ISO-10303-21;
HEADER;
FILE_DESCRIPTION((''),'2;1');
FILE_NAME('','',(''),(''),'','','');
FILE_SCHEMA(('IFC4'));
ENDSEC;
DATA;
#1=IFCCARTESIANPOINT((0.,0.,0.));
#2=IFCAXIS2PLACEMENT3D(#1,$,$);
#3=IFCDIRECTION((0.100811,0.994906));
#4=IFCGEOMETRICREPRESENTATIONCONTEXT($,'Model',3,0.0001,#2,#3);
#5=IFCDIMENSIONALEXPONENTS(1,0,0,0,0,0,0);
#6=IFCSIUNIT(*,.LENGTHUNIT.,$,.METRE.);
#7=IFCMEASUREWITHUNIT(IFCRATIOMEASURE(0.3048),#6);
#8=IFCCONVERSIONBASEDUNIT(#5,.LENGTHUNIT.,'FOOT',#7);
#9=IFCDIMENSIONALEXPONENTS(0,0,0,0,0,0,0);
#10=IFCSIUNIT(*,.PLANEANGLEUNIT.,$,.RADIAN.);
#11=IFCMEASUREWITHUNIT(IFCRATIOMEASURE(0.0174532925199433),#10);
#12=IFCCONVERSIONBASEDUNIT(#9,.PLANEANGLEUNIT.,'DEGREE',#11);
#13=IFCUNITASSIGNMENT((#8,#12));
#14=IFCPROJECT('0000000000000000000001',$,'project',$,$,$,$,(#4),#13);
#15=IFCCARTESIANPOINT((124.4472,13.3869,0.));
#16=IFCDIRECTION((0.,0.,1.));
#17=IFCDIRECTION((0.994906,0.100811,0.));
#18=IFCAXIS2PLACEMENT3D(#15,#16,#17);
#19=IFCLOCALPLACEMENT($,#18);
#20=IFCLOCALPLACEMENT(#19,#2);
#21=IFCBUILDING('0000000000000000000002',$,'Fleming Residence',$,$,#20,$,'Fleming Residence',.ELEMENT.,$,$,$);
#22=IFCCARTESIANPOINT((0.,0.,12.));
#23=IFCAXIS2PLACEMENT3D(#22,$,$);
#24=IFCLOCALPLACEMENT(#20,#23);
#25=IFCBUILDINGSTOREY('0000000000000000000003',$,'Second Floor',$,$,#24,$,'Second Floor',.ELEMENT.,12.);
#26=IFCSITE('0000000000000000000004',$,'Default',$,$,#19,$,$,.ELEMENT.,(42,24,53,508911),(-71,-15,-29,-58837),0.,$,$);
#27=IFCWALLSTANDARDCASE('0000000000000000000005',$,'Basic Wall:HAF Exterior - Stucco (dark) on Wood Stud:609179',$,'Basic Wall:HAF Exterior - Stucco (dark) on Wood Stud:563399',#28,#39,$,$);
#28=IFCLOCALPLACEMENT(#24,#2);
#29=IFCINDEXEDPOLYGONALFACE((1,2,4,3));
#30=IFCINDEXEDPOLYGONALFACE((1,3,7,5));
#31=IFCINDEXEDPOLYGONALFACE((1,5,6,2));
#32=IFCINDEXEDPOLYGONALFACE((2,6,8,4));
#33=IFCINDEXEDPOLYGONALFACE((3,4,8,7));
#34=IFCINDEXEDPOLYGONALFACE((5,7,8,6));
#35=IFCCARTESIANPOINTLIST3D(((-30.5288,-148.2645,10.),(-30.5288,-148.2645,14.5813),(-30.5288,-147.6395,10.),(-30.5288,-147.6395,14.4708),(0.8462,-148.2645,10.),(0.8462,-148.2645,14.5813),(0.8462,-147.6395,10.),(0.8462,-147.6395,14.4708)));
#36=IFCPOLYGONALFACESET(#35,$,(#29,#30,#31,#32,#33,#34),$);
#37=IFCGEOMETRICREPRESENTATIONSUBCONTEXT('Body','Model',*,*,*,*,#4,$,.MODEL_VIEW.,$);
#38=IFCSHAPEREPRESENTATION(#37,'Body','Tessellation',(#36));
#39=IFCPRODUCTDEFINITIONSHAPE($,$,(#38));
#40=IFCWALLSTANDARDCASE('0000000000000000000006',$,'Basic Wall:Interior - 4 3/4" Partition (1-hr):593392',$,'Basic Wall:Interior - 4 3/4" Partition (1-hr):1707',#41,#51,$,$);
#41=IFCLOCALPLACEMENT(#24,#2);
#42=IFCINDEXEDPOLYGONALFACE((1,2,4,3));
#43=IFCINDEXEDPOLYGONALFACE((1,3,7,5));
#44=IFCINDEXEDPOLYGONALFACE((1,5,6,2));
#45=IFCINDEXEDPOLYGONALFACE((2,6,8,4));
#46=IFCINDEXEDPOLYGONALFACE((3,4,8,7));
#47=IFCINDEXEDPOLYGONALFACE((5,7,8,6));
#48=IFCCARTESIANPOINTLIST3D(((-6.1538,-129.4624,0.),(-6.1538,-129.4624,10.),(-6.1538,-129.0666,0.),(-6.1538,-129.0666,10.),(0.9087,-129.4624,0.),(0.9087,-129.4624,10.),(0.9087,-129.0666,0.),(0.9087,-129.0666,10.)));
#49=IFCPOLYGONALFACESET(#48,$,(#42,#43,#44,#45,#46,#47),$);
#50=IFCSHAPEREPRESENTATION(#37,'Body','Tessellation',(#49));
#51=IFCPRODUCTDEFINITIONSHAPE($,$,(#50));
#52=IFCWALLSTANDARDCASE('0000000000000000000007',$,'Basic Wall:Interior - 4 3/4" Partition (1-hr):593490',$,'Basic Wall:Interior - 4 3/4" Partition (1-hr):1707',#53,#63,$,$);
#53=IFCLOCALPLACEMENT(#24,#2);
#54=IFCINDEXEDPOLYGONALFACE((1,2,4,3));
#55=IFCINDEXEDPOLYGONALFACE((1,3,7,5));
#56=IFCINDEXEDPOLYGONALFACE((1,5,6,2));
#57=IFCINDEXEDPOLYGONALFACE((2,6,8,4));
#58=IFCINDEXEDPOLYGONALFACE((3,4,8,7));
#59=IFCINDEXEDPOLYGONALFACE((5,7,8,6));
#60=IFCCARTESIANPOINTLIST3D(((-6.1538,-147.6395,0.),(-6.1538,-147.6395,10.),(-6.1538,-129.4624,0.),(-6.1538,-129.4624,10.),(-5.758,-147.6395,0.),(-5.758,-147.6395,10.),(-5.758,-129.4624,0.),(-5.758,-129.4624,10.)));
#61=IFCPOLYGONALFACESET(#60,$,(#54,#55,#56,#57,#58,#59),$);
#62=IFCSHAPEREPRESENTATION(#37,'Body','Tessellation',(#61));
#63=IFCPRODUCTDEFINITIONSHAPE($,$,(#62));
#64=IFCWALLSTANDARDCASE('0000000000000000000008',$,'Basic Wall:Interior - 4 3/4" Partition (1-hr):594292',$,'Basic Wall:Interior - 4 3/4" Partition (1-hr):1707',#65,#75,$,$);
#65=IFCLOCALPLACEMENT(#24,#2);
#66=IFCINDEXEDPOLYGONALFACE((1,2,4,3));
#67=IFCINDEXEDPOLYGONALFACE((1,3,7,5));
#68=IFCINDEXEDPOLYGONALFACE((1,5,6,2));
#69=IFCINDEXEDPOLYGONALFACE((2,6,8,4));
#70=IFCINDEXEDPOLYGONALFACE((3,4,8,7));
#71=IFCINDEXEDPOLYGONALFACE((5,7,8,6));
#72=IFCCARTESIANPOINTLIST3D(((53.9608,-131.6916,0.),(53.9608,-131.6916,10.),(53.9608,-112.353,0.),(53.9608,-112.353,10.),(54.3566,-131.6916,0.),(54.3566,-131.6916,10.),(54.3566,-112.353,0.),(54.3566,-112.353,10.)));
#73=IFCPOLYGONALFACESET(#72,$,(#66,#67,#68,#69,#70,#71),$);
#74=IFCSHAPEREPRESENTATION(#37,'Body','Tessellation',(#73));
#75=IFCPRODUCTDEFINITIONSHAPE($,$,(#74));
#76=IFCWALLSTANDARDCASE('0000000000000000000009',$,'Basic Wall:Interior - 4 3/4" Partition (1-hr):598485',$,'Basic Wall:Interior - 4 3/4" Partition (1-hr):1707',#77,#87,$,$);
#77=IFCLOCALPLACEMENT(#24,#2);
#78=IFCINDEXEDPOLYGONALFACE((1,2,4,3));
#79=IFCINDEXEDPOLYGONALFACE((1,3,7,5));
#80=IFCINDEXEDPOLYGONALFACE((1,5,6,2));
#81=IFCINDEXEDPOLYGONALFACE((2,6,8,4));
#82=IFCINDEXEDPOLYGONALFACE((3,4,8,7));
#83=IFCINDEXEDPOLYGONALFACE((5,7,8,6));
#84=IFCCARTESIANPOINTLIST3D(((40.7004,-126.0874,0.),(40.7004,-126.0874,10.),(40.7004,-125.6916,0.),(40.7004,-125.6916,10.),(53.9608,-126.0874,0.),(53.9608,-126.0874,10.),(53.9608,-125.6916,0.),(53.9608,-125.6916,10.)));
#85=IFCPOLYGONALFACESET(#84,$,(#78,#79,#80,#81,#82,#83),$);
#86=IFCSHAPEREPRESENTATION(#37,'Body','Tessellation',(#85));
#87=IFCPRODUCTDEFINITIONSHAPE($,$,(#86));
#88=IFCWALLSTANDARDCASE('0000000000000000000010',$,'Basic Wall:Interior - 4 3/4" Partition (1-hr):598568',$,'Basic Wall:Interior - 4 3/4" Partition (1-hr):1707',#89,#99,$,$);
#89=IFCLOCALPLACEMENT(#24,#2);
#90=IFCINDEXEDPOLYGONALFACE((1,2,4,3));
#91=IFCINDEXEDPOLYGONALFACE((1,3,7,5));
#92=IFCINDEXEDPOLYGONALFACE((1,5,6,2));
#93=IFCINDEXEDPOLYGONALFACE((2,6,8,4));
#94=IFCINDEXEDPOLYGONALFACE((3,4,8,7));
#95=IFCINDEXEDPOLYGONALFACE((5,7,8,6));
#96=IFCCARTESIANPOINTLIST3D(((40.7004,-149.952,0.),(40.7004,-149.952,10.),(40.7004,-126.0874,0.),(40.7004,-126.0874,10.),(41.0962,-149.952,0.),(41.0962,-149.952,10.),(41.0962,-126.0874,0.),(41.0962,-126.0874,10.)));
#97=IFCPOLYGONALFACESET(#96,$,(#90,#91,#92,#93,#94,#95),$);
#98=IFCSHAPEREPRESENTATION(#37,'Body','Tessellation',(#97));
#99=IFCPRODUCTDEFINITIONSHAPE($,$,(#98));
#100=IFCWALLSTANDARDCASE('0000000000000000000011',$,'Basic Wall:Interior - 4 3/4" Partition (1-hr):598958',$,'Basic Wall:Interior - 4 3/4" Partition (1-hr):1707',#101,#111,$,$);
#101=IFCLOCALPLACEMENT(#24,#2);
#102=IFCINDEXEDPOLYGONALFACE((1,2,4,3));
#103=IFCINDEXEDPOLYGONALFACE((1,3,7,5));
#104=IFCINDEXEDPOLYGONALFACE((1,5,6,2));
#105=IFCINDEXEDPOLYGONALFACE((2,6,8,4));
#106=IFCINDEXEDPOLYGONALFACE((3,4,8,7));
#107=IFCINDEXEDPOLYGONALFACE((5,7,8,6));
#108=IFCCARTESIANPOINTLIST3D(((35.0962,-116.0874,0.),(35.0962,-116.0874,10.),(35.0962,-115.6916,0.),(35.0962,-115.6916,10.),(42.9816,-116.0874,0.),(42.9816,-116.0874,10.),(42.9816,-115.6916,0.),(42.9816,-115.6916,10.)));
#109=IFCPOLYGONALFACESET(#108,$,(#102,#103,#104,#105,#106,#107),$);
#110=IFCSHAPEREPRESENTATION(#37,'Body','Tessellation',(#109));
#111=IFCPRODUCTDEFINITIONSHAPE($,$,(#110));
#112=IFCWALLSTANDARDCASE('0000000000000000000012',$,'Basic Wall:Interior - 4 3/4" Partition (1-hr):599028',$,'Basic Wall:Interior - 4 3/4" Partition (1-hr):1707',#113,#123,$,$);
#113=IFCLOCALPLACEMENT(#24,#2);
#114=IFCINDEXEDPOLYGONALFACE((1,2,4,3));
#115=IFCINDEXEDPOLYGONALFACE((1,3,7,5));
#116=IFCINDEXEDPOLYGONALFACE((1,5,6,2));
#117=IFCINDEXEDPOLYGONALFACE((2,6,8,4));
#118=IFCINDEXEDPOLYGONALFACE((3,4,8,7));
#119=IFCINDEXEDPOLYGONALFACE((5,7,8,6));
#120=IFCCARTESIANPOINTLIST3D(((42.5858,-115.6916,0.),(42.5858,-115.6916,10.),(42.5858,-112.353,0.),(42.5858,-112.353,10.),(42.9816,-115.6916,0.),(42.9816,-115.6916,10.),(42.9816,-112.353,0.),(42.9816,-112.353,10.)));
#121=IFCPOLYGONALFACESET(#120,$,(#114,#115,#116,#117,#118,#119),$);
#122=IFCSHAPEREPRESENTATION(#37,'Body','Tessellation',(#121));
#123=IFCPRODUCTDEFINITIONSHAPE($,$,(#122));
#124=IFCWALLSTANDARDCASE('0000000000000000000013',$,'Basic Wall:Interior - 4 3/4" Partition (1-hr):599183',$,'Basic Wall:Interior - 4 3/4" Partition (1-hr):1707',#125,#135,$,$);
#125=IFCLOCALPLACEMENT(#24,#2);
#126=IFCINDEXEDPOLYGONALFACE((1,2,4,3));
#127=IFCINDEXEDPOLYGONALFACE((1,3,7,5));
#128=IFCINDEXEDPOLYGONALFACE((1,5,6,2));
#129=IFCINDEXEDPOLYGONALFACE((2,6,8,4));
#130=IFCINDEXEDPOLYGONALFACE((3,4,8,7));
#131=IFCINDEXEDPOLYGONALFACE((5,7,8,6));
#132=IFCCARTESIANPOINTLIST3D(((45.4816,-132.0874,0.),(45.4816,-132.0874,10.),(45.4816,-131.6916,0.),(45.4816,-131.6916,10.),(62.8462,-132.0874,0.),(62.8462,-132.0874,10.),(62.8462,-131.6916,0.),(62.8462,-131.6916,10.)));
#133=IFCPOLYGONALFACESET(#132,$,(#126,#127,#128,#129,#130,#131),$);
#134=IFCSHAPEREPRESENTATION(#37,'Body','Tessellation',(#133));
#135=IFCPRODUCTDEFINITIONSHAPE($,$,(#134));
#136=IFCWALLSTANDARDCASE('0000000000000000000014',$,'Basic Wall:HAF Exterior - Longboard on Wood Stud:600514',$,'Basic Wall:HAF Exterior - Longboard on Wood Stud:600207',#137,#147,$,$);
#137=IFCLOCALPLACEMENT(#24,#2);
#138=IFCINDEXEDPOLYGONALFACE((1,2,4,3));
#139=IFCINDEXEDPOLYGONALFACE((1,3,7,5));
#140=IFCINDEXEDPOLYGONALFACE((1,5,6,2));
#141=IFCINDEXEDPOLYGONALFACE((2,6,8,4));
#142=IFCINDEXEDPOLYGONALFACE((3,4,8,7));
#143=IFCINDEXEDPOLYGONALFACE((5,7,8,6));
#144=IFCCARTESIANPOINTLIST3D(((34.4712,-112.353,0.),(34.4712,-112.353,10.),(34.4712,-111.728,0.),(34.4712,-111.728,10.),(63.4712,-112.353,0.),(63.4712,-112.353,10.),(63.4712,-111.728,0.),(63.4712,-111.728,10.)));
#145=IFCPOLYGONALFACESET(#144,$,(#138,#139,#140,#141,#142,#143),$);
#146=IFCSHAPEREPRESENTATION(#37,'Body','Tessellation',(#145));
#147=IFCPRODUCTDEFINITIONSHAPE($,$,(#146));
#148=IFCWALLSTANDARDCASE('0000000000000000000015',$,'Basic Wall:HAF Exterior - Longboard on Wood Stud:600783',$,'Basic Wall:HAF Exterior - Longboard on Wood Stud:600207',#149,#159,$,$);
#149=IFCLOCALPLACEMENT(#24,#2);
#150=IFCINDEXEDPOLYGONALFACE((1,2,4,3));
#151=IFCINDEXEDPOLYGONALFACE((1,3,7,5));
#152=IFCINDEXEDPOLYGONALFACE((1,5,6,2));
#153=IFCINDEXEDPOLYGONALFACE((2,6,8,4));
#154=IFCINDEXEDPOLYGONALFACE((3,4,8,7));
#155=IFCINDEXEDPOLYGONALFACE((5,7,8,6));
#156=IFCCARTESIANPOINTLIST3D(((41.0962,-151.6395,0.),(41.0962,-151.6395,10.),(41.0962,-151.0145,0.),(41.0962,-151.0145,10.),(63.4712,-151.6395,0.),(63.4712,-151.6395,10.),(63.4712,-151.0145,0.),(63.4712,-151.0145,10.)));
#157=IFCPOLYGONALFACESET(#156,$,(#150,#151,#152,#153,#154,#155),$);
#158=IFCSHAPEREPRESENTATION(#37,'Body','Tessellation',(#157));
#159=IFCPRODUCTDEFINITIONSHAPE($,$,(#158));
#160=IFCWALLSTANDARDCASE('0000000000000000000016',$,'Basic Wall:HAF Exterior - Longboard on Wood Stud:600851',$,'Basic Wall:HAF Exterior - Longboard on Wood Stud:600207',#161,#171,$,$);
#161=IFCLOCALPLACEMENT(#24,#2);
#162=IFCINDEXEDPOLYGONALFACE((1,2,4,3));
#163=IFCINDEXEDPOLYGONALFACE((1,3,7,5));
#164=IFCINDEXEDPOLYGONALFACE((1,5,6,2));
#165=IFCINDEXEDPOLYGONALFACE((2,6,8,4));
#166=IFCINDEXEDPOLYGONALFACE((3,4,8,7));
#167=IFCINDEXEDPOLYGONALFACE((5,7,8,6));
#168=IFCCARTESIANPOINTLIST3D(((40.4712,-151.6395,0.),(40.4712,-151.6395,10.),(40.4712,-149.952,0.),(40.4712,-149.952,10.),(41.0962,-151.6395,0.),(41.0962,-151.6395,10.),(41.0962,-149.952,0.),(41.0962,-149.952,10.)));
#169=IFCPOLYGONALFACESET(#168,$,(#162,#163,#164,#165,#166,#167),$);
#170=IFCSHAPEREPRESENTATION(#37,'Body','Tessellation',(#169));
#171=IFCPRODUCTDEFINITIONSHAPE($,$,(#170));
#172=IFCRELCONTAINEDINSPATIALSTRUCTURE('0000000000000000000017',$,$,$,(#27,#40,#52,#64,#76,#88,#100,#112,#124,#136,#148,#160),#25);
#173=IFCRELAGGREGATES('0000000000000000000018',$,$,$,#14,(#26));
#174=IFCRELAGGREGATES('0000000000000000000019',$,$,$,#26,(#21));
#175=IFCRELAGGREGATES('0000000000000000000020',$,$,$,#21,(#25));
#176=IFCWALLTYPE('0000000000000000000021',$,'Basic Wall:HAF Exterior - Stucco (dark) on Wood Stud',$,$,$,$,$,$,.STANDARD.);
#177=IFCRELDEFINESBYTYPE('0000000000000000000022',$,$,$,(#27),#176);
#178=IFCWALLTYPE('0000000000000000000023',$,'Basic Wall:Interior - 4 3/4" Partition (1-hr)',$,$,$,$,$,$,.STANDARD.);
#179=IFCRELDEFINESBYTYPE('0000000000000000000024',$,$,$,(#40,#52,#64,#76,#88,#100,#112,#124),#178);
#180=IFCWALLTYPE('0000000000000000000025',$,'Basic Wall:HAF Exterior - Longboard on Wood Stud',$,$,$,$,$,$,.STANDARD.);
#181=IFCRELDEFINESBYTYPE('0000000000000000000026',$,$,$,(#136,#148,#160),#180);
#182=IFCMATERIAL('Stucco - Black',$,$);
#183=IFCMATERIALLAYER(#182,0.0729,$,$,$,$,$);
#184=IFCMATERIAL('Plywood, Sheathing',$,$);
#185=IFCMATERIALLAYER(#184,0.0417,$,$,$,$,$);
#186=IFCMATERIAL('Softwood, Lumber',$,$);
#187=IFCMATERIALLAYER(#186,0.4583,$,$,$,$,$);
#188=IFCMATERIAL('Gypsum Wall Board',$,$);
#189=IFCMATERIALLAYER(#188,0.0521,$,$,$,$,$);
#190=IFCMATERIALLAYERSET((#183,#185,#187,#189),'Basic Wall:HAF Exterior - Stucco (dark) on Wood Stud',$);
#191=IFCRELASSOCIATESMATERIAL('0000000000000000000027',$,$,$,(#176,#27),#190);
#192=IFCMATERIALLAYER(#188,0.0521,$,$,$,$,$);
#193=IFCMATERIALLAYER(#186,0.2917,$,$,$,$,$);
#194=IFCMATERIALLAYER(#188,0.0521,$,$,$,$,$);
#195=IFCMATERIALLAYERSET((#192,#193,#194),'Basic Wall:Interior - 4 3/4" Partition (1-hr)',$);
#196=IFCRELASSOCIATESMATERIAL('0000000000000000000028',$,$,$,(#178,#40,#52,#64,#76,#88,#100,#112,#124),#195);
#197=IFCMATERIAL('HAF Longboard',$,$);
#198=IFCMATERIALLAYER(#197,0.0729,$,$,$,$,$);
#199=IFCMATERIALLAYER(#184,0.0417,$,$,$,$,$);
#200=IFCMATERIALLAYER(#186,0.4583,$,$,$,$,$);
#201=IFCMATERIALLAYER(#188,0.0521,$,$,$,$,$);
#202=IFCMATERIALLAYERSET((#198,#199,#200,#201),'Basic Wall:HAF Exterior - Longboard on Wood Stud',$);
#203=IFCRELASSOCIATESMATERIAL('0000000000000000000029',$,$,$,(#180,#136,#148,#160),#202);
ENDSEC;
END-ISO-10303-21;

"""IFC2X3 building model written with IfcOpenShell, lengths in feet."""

from ifc_helpers import new_model, entity, si_unit, converted_unit, direction, frame, frame_2d, origin, place, context, subcontext, project, spatial, polyline, rectangle, extrude, clip, bounded_halfspace, material, layer, layer_set, layer_usage, type_object, element, save


model = new_model("IFC2X3")

# Units and contexts
model_context = context("Model", 3, precision=0.0001, world=origin(), true_north=direction((0.100811, 0.994906)))
body_context = subcontext(model_context, "Body", "Model", "MODEL_VIEW")
ifc_project = project(units=[converted_unit("LENGTHUNIT", "FOOT", entity("IfcRatioMeasure", 0.3048), si_unit("LENGTHUNIT", "METRE"), dimensions=[1, 0, 0, 0, 0, 0, 0]), converted_unit("PLANEANGLEUNIT", "DEGREE", entity("IfcRatioMeasure", 0.0174532925199433), si_unit("PLANEANGLEUNIT", "RADIAN"), dimensions=[0, 0, 0, 0, 0, 0, 0])], contexts=[model_context])

# Site, building, storey
site_placement = place(None, frame((124.4472, 13.3869, 0.0), z_axis=(0.0, 0.0, 1.0), x_axis=(0.994906, 0.100811, 0.0)))
site = spatial("IfcSite", under=ifc_project, at=site_placement, Name="Default", CompositionType="ELEMENT", RefLatitude=(42, 24, 53, 508911), RefLongitude=(-71, -15, -29, -58837), RefElevation=0.0)
building_placement = place(site_placement, origin())
building = spatial("IfcBuilding", under=site, at=building_placement, Name="Fleming Residence", LongName="Fleming Residence", CompositionType="ELEMENT")
storey_placement = place(building_placement, frame((0.0, 0.0, 12.0)))
storey = spatial("IfcBuildingStorey", under=building, at=storey_placement, Name="Second Floor", LongName="Second Floor", CompositionType="ELEMENT", Elevation=12.0)

# Walls
ifc_material_1 = material(Name="Plywood, Sheathing")
ifc_material_2 = material(Name="Softwood, Lumber")
ifc_material_3 = material(Name="Gypsum Wall Board")
ifc_material_4 = material(Name="Stucco - Black")
ifc_layer_1 = layer(ifc_material_4, 0.0729)
ifc_layer_2 = layer(ifc_material_1, 0.0417)
ifc_layer_3 = layer(ifc_material_2, 0.4583)
ifc_layer_4 = layer(ifc_material_3, 0.0521)
ifc_layer_set_1 = layer_set([ifc_layer_1, ifc_layer_2, ifc_layer_3, ifc_layer_4], Name="Basic Wall:HAF Exterior - Stucco (dark) on Wood Stud")
wall_type_1 = type_object("IfcWallType", Name="Basic Wall:HAF Exterior - Stucco (dark) on Wood Stud", PredefinedType="STANDARD", material=ifc_layer_set_1)
ifc_layer_usage_1 = layer_usage(ifc_layer_set_1, "AXIS2", "NEGATIVE", 0.3125)
wall_1_placement = place(storey_placement, frame((0.8462, -147.952, 10.0), z_axis=(0.0, 0.0, 1.0), x_axis=(-1.0, 0.0, 0.0)))
element("IfcWallStandardCase", 1, at=wall_1_placement, inside=storey, type_object=wall_type_1, material=ifc_layer_usage_1, Name="Basic Wall:HAF Exterior - Stucco (dark) on Wood Stud:609179", ObjectType="Basic Wall:HAF Exterior - Stucco (dark) on Wood Stud:563399", context=body_context, shape_type="Clipping", body=[
    clip(extrude(rectangle(XDim=31.375, YDim=0.625, at=frame_2d((15.6875, 0.0), x_axis=(-1.0, 0.0))), origin(), (0.0, 0.0, 1.0), 4.5813), bounded_halfspace(frame((0.0, -0.3125, 4.4708), z_axis=(0.0, 0.174064, -0.984734), x_axis=(1.0, 0.0, 0.0)), True, frame((0.0, -0.3125, 4.4708)), polyline([(0.0, 0.0), (30.75, 0.0), (31.375, 0.0), (31.375, 0.625), (0.0, 0.625), (0.0, 0.0)]))),
])
ifc_layer_5 = layer(ifc_material_3, 0.0521)
ifc_layer_6 = layer(ifc_material_2, 0.2917)
ifc_layer_7 = layer(ifc_material_3, 0.0521)
ifc_layer_set_2 = layer_set([ifc_layer_5, ifc_layer_6, ifc_layer_7], Name="Basic Wall:Interior - 4 3/4\" Partition (1-hr)")
ifc_layer_usage_2 = layer_usage(ifc_layer_set_2, "AXIS2", "NEGATIVE", 0.1979)
wall_type_2 = type_object("IfcWallType", Name="Basic Wall:Interior - 4 3/4\" Partition (1-hr)", PredefinedType="STANDARD", material=ifc_layer_set_2)
wall_2_placement = place(storey_placement, frame((0.9087, -129.2645, 0.0), z_axis=(0.0, 0.0, 1.0), x_axis=(-1.0, 0.0, 0.0)))
element("IfcWallStandardCase", 2, at=wall_2_placement, inside=storey, type_object=wall_type_2, material=ifc_layer_usage_2, Name="Basic Wall:Interior - 4 3/4\" Partition (1-hr):593392", ObjectType="Basic Wall:Interior - 4 3/4\" Partition (1-hr):1707", context=body_context, shape_type="SweptSolid", body=[
    extrude(rectangle(XDim=7.0625, YDim=0.3958, at=frame_2d((3.5313, 0.0), x_axis=(-1.0, 0.0))), origin(), (0.0, 0.0, 1.0), 10.0),
])
ifc_layer_usage_3 = layer_usage(ifc_layer_set_2, "AXIS2", "NEGATIVE", 0.1979)
wall_3_placement = place(storey_placement, frame((-5.9559, -129.4624, 0.0), z_axis=(0.0, 0.0, 1.0), x_axis=(0.0, -1.0, 0.0)))
element("IfcWallStandardCase", 3, at=wall_3_placement, inside=storey, type_object=wall_type_2, material=ifc_layer_usage_3, Name="Basic Wall:Interior - 4 3/4\" Partition (1-hr):593490", ObjectType="Basic Wall:Interior - 4 3/4\" Partition (1-hr):1707", context=body_context, shape_type="SweptSolid", body=[
    extrude(rectangle(XDim=18.1771, YDim=0.3958, at=frame_2d((9.0885, 0.0), x_axis=(-1.0, 0.0))), origin(), (0.0, 0.0, 1.0), 10.0),
])
ifc_layer_usage_4 = layer_usage(ifc_layer_set_2, "AXIS2", "NEGATIVE", 0.1979)
wall_4_placement = place(storey_placement, frame((54.1587, -112.353, 0.0), z_axis=(0.0, 0.0, 1.0), x_axis=(0.0, -1.0, 0.0)))
element("IfcWallStandardCase", 4, at=wall_4_placement, inside=storey, type_object=wall_type_2, material=ifc_layer_usage_4, Name="Basic Wall:Interior - 4 3/4\" Partition (1-hr):594292", ObjectType="Basic Wall:Interior - 4 3/4\" Partition (1-hr):1707", context=body_context, shape_type="SweptSolid", body=[
    extrude(rectangle(XDim=19.3385, YDim=0.3958, at=frame_2d((9.6693, 0.0), x_axis=(-1.0, 0.0))), origin(), (0.0, 0.0, 1.0), 10.0),
])
ifc_layer_usage_5 = layer_usage(ifc_layer_set_2, "AXIS2", "NEGATIVE", 0.1979)
wall_5_placement = place(storey_placement, frame((53.9608, -125.8895, 0.0), z_axis=(0.0, 0.0, 1.0), x_axis=(-1.0, 0.0, 0.0)))
element("IfcWallStandardCase", 5, at=wall_5_placement, inside=storey, type_object=wall_type_2, material=ifc_layer_usage_5, Name="Basic Wall:Interior - 4 3/4\" Partition (1-hr):598485", ObjectType="Basic Wall:Interior - 4 3/4\" Partition (1-hr):1707", context=body_context, shape_type="SweptSolid", body=[
    extrude(rectangle(XDim=13.2604, YDim=0.3958, at=frame_2d((6.6302, 0.0), x_axis=(-1.0, 0.0))), origin(), (0.0, 0.0, 1.0), 10.0),
])
ifc_layer_usage_6 = layer_usage(ifc_layer_set_2, "AXIS2", "NEGATIVE", 0.1979)
wall_6_placement = place(storey_placement, frame((40.8983, -126.0874, 0.0), z_axis=(0.0, 0.0, 1.0), x_axis=(0.0, -1.0, 0.0)))
element("IfcWallStandardCase", 6, at=wall_6_placement, inside=storey, type_object=wall_type_2, material=ifc_layer_usage_6, Name="Basic Wall:Interior - 4 3/4\" Partition (1-hr):598568", ObjectType="Basic Wall:Interior - 4 3/4\" Partition (1-hr):1707", context=body_context, shape_type="SweptSolid", body=[
    extrude(rectangle(XDim=23.8646, YDim=0.3958, at=frame_2d((11.9323, 0.0), x_axis=(-1.0, 0.0))), origin(), (0.0, 0.0, 1.0), 10.0),
])
ifc_layer_usage_7 = layer_usage(ifc_layer_set_2, "AXIS2", "NEGATIVE", 0.1979)
wall_7_placement = place(storey_placement, frame((35.0962, -115.8895, 0.0)))
element("IfcWallStandardCase", 7, at=wall_7_placement, inside=storey, type_object=wall_type_2, material=ifc_layer_usage_7, Name="Basic Wall:Interior - 4 3/4\" Partition (1-hr):598958", ObjectType="Basic Wall:Interior - 4 3/4\" Partition (1-hr):1707", context=body_context, shape_type="SweptSolid", body=[
    extrude(rectangle(XDim=7.8854, YDim=0.3958, at=frame_2d((3.9427, 0.0), x_axis=(-1.0, 0.0))), origin(), (0.0, 0.0, 1.0), 10.0),
])
ifc_layer_usage_8 = layer_usage(ifc_layer_set_2, "AXIS2", "NEGATIVE", 0.1979)
wall_8_placement = place(storey_placement, frame((42.7837, -115.6916, 0.0), z_axis=(0.0, 0.0, 1.0), x_axis=(0.0, 1.0, 0.0)))
element("IfcWallStandardCase", 8, at=wall_8_placement, inside=storey, type_object=wall_type_2, material=ifc_layer_usage_8, Name="Basic Wall:Interior - 4 3/4\" Partition (1-hr):599028", ObjectType="Basic Wall:Interior - 4 3/4\" Partition (1-hr):1707", context=body_context, shape_type="SweptSolid", body=[
    extrude(rectangle(XDim=3.3385, YDim=0.3958, at=frame_2d((1.6693, 0.0), x_axis=(-1.0, 0.0))), origin(), (0.0, 0.0, 1.0), 10.0),
])
ifc_layer_usage_9 = layer_usage(ifc_layer_set_2, "AXIS2", "NEGATIVE", 0.1979)
wall_9_placement = place(storey_placement, frame((45.4816, -131.8895, 0.0)))
element("IfcWallStandardCase", 9, at=wall_9_placement, inside=storey, type_object=wall_type_2, material=ifc_layer_usage_9, Name="Basic Wall:Interior - 4 3/4\" Partition (1-hr):599183", ObjectType="Basic Wall:Interior - 4 3/4\" Partition (1-hr):1707", context=body_context, shape_type="SweptSolid", body=[
    extrude(rectangle(XDim=17.3646, YDim=0.3958, at=frame_2d((8.6823, 0.0), x_axis=(-1.0, 0.0))), origin(), (0.0, 0.0, 1.0), 10.0),
])
ifc_material_5 = material(Name="HAF Longboard")
ifc_layer_8 = layer(ifc_material_5, 0.0729)
ifc_layer_9 = layer(ifc_material_1, 0.0417)
ifc_layer_10 = layer(ifc_material_2, 0.4583)
ifc_layer_11 = layer(ifc_material_3, 0.0521)
ifc_layer_set_3 = layer_set([ifc_layer_8, ifc_layer_9, ifc_layer_10, ifc_layer_11], Name="Basic Wall:HAF Exterior - Longboard on Wood Stud")
ifc_layer_usage_10 = layer_usage(ifc_layer_set_3, "AXIS2", "NEGATIVE", 0.3125)
wall_type_3 = type_object("IfcWallType", Name="Basic Wall:HAF Exterior - Longboard on Wood Stud", PredefinedType="STANDARD", material=ifc_layer_set_3)
wall_10_placement = place(storey_placement, frame((34.4712, -112.0405, 0.0)))
element("IfcWallStandardCase", 10, at=wall_10_placement, inside=storey, type_object=wall_type_3, material=ifc_layer_usage_10, Name="Basic Wall:HAF Exterior - Longboard on Wood Stud:600514", ObjectType="Basic Wall:HAF Exterior - Longboard on Wood Stud:600207", context=body_context, shape_type="Clipping", body=[
    clip(extrude(rectangle(XDim=29.0, YDim=0.625, at=frame_2d((14.5, 0.0), x_axis=(-1.0, 0.0))), origin(), (0.0, 0.0, 1.0), 10.0), bounded_halfspace(frame((0.0, -0.3125, 10.0), z_axis=(0.0, 0.0, -1.0), x_axis=(0.0, 1.0, 0.0)), True, frame((0.0, -0.3125, 10.0)), polyline([(0.0, 0.0), (0.625, 0.0), (8.1146, 0.0), (8.5104, 0.0), (19.4896, 0.0), (19.8854, 0.0), (28.375, 0.0), (29.0, 0.0), (29.0, 0.625), (0.625, 0.625), (0.0, 0.625), (0.0, 0.0)]))),
])
ifc_layer_usage_11 = layer_usage(ifc_layer_set_3, "AXIS2", "POSITIVE", -0.3125)
wall_11_placement = place(storey_placement, frame((41.0962, -151.327, 0.0)))
element("IfcWallStandardCase", 11, at=wall_11_placement, inside=storey, type_object=wall_type_3, material=ifc_layer_usage_11, Name="Basic Wall:HAF Exterior - Longboard on Wood Stud:600783", ObjectType="Basic Wall:HAF Exterior - Longboard on Wood Stud:600207", context=body_context, shape_type="Clipping", body=[
    clip(extrude(rectangle(XDim=22.375, YDim=0.625, at=frame_2d((11.1875, 0.0), x_axis=(-1.0, 0.0))), origin(), (0.0, 0.0, 1.0), 10.0), bounded_halfspace(frame((0.0, -0.3125, 10.0), z_axis=(0.0, 0.0, -1.0), x_axis=(0.0, 1.0, 0.0)), True, frame((0.0, -0.3125, 10.0)), polyline([(0.0, 0.0), (22.375, 0.0), (22.375, 0.625), (21.75, 0.625), (0.0, 0.625), (0.0, 0.0)]))),
])
ifc_layer_usage_12 = layer_usage(ifc_layer_set_3, "AXIS2", "NEGATIVE", 0.3125)
wall_12_placement = place(storey_placement, frame((40.7837, -151.6395, 0.0), z_axis=(0.0, 0.0, 1.0), x_axis=(0.0, 1.0, 0.0)))
element("IfcWallStandardCase", 12, at=wall_12_placement, inside=storey, type_object=wall_type_3, material=ifc_layer_usage_12, Name="Basic Wall:HAF Exterior - Longboard on Wood Stud:600851", ObjectType="Basic Wall:HAF Exterior - Longboard on Wood Stud:600207", context=body_context, shape_type="Clipping", body=[
    clip(extrude(rectangle(XDim=1.6875, YDim=0.625, at=frame_2d((0.8438, 0.0), x_axis=(-1.0, 0.0))), origin(), (0.0, 0.0, 1.0), 10.0), bounded_halfspace(frame((0.0, -0.3125, 10.0), z_axis=(0.0, 0.0, -1.0), x_axis=(0.0, 1.0, 0.0)), True, frame((0.0, -0.3125, 10.0)), polyline([(0.0, 0.0), (0.625, 0.0), (1.6875, 0.0), (1.6875, 0.625), (0.625, 0.625), (0.0, 0.625), (0.0, 0.0)]))),
])

save(model, "model.ifc")
